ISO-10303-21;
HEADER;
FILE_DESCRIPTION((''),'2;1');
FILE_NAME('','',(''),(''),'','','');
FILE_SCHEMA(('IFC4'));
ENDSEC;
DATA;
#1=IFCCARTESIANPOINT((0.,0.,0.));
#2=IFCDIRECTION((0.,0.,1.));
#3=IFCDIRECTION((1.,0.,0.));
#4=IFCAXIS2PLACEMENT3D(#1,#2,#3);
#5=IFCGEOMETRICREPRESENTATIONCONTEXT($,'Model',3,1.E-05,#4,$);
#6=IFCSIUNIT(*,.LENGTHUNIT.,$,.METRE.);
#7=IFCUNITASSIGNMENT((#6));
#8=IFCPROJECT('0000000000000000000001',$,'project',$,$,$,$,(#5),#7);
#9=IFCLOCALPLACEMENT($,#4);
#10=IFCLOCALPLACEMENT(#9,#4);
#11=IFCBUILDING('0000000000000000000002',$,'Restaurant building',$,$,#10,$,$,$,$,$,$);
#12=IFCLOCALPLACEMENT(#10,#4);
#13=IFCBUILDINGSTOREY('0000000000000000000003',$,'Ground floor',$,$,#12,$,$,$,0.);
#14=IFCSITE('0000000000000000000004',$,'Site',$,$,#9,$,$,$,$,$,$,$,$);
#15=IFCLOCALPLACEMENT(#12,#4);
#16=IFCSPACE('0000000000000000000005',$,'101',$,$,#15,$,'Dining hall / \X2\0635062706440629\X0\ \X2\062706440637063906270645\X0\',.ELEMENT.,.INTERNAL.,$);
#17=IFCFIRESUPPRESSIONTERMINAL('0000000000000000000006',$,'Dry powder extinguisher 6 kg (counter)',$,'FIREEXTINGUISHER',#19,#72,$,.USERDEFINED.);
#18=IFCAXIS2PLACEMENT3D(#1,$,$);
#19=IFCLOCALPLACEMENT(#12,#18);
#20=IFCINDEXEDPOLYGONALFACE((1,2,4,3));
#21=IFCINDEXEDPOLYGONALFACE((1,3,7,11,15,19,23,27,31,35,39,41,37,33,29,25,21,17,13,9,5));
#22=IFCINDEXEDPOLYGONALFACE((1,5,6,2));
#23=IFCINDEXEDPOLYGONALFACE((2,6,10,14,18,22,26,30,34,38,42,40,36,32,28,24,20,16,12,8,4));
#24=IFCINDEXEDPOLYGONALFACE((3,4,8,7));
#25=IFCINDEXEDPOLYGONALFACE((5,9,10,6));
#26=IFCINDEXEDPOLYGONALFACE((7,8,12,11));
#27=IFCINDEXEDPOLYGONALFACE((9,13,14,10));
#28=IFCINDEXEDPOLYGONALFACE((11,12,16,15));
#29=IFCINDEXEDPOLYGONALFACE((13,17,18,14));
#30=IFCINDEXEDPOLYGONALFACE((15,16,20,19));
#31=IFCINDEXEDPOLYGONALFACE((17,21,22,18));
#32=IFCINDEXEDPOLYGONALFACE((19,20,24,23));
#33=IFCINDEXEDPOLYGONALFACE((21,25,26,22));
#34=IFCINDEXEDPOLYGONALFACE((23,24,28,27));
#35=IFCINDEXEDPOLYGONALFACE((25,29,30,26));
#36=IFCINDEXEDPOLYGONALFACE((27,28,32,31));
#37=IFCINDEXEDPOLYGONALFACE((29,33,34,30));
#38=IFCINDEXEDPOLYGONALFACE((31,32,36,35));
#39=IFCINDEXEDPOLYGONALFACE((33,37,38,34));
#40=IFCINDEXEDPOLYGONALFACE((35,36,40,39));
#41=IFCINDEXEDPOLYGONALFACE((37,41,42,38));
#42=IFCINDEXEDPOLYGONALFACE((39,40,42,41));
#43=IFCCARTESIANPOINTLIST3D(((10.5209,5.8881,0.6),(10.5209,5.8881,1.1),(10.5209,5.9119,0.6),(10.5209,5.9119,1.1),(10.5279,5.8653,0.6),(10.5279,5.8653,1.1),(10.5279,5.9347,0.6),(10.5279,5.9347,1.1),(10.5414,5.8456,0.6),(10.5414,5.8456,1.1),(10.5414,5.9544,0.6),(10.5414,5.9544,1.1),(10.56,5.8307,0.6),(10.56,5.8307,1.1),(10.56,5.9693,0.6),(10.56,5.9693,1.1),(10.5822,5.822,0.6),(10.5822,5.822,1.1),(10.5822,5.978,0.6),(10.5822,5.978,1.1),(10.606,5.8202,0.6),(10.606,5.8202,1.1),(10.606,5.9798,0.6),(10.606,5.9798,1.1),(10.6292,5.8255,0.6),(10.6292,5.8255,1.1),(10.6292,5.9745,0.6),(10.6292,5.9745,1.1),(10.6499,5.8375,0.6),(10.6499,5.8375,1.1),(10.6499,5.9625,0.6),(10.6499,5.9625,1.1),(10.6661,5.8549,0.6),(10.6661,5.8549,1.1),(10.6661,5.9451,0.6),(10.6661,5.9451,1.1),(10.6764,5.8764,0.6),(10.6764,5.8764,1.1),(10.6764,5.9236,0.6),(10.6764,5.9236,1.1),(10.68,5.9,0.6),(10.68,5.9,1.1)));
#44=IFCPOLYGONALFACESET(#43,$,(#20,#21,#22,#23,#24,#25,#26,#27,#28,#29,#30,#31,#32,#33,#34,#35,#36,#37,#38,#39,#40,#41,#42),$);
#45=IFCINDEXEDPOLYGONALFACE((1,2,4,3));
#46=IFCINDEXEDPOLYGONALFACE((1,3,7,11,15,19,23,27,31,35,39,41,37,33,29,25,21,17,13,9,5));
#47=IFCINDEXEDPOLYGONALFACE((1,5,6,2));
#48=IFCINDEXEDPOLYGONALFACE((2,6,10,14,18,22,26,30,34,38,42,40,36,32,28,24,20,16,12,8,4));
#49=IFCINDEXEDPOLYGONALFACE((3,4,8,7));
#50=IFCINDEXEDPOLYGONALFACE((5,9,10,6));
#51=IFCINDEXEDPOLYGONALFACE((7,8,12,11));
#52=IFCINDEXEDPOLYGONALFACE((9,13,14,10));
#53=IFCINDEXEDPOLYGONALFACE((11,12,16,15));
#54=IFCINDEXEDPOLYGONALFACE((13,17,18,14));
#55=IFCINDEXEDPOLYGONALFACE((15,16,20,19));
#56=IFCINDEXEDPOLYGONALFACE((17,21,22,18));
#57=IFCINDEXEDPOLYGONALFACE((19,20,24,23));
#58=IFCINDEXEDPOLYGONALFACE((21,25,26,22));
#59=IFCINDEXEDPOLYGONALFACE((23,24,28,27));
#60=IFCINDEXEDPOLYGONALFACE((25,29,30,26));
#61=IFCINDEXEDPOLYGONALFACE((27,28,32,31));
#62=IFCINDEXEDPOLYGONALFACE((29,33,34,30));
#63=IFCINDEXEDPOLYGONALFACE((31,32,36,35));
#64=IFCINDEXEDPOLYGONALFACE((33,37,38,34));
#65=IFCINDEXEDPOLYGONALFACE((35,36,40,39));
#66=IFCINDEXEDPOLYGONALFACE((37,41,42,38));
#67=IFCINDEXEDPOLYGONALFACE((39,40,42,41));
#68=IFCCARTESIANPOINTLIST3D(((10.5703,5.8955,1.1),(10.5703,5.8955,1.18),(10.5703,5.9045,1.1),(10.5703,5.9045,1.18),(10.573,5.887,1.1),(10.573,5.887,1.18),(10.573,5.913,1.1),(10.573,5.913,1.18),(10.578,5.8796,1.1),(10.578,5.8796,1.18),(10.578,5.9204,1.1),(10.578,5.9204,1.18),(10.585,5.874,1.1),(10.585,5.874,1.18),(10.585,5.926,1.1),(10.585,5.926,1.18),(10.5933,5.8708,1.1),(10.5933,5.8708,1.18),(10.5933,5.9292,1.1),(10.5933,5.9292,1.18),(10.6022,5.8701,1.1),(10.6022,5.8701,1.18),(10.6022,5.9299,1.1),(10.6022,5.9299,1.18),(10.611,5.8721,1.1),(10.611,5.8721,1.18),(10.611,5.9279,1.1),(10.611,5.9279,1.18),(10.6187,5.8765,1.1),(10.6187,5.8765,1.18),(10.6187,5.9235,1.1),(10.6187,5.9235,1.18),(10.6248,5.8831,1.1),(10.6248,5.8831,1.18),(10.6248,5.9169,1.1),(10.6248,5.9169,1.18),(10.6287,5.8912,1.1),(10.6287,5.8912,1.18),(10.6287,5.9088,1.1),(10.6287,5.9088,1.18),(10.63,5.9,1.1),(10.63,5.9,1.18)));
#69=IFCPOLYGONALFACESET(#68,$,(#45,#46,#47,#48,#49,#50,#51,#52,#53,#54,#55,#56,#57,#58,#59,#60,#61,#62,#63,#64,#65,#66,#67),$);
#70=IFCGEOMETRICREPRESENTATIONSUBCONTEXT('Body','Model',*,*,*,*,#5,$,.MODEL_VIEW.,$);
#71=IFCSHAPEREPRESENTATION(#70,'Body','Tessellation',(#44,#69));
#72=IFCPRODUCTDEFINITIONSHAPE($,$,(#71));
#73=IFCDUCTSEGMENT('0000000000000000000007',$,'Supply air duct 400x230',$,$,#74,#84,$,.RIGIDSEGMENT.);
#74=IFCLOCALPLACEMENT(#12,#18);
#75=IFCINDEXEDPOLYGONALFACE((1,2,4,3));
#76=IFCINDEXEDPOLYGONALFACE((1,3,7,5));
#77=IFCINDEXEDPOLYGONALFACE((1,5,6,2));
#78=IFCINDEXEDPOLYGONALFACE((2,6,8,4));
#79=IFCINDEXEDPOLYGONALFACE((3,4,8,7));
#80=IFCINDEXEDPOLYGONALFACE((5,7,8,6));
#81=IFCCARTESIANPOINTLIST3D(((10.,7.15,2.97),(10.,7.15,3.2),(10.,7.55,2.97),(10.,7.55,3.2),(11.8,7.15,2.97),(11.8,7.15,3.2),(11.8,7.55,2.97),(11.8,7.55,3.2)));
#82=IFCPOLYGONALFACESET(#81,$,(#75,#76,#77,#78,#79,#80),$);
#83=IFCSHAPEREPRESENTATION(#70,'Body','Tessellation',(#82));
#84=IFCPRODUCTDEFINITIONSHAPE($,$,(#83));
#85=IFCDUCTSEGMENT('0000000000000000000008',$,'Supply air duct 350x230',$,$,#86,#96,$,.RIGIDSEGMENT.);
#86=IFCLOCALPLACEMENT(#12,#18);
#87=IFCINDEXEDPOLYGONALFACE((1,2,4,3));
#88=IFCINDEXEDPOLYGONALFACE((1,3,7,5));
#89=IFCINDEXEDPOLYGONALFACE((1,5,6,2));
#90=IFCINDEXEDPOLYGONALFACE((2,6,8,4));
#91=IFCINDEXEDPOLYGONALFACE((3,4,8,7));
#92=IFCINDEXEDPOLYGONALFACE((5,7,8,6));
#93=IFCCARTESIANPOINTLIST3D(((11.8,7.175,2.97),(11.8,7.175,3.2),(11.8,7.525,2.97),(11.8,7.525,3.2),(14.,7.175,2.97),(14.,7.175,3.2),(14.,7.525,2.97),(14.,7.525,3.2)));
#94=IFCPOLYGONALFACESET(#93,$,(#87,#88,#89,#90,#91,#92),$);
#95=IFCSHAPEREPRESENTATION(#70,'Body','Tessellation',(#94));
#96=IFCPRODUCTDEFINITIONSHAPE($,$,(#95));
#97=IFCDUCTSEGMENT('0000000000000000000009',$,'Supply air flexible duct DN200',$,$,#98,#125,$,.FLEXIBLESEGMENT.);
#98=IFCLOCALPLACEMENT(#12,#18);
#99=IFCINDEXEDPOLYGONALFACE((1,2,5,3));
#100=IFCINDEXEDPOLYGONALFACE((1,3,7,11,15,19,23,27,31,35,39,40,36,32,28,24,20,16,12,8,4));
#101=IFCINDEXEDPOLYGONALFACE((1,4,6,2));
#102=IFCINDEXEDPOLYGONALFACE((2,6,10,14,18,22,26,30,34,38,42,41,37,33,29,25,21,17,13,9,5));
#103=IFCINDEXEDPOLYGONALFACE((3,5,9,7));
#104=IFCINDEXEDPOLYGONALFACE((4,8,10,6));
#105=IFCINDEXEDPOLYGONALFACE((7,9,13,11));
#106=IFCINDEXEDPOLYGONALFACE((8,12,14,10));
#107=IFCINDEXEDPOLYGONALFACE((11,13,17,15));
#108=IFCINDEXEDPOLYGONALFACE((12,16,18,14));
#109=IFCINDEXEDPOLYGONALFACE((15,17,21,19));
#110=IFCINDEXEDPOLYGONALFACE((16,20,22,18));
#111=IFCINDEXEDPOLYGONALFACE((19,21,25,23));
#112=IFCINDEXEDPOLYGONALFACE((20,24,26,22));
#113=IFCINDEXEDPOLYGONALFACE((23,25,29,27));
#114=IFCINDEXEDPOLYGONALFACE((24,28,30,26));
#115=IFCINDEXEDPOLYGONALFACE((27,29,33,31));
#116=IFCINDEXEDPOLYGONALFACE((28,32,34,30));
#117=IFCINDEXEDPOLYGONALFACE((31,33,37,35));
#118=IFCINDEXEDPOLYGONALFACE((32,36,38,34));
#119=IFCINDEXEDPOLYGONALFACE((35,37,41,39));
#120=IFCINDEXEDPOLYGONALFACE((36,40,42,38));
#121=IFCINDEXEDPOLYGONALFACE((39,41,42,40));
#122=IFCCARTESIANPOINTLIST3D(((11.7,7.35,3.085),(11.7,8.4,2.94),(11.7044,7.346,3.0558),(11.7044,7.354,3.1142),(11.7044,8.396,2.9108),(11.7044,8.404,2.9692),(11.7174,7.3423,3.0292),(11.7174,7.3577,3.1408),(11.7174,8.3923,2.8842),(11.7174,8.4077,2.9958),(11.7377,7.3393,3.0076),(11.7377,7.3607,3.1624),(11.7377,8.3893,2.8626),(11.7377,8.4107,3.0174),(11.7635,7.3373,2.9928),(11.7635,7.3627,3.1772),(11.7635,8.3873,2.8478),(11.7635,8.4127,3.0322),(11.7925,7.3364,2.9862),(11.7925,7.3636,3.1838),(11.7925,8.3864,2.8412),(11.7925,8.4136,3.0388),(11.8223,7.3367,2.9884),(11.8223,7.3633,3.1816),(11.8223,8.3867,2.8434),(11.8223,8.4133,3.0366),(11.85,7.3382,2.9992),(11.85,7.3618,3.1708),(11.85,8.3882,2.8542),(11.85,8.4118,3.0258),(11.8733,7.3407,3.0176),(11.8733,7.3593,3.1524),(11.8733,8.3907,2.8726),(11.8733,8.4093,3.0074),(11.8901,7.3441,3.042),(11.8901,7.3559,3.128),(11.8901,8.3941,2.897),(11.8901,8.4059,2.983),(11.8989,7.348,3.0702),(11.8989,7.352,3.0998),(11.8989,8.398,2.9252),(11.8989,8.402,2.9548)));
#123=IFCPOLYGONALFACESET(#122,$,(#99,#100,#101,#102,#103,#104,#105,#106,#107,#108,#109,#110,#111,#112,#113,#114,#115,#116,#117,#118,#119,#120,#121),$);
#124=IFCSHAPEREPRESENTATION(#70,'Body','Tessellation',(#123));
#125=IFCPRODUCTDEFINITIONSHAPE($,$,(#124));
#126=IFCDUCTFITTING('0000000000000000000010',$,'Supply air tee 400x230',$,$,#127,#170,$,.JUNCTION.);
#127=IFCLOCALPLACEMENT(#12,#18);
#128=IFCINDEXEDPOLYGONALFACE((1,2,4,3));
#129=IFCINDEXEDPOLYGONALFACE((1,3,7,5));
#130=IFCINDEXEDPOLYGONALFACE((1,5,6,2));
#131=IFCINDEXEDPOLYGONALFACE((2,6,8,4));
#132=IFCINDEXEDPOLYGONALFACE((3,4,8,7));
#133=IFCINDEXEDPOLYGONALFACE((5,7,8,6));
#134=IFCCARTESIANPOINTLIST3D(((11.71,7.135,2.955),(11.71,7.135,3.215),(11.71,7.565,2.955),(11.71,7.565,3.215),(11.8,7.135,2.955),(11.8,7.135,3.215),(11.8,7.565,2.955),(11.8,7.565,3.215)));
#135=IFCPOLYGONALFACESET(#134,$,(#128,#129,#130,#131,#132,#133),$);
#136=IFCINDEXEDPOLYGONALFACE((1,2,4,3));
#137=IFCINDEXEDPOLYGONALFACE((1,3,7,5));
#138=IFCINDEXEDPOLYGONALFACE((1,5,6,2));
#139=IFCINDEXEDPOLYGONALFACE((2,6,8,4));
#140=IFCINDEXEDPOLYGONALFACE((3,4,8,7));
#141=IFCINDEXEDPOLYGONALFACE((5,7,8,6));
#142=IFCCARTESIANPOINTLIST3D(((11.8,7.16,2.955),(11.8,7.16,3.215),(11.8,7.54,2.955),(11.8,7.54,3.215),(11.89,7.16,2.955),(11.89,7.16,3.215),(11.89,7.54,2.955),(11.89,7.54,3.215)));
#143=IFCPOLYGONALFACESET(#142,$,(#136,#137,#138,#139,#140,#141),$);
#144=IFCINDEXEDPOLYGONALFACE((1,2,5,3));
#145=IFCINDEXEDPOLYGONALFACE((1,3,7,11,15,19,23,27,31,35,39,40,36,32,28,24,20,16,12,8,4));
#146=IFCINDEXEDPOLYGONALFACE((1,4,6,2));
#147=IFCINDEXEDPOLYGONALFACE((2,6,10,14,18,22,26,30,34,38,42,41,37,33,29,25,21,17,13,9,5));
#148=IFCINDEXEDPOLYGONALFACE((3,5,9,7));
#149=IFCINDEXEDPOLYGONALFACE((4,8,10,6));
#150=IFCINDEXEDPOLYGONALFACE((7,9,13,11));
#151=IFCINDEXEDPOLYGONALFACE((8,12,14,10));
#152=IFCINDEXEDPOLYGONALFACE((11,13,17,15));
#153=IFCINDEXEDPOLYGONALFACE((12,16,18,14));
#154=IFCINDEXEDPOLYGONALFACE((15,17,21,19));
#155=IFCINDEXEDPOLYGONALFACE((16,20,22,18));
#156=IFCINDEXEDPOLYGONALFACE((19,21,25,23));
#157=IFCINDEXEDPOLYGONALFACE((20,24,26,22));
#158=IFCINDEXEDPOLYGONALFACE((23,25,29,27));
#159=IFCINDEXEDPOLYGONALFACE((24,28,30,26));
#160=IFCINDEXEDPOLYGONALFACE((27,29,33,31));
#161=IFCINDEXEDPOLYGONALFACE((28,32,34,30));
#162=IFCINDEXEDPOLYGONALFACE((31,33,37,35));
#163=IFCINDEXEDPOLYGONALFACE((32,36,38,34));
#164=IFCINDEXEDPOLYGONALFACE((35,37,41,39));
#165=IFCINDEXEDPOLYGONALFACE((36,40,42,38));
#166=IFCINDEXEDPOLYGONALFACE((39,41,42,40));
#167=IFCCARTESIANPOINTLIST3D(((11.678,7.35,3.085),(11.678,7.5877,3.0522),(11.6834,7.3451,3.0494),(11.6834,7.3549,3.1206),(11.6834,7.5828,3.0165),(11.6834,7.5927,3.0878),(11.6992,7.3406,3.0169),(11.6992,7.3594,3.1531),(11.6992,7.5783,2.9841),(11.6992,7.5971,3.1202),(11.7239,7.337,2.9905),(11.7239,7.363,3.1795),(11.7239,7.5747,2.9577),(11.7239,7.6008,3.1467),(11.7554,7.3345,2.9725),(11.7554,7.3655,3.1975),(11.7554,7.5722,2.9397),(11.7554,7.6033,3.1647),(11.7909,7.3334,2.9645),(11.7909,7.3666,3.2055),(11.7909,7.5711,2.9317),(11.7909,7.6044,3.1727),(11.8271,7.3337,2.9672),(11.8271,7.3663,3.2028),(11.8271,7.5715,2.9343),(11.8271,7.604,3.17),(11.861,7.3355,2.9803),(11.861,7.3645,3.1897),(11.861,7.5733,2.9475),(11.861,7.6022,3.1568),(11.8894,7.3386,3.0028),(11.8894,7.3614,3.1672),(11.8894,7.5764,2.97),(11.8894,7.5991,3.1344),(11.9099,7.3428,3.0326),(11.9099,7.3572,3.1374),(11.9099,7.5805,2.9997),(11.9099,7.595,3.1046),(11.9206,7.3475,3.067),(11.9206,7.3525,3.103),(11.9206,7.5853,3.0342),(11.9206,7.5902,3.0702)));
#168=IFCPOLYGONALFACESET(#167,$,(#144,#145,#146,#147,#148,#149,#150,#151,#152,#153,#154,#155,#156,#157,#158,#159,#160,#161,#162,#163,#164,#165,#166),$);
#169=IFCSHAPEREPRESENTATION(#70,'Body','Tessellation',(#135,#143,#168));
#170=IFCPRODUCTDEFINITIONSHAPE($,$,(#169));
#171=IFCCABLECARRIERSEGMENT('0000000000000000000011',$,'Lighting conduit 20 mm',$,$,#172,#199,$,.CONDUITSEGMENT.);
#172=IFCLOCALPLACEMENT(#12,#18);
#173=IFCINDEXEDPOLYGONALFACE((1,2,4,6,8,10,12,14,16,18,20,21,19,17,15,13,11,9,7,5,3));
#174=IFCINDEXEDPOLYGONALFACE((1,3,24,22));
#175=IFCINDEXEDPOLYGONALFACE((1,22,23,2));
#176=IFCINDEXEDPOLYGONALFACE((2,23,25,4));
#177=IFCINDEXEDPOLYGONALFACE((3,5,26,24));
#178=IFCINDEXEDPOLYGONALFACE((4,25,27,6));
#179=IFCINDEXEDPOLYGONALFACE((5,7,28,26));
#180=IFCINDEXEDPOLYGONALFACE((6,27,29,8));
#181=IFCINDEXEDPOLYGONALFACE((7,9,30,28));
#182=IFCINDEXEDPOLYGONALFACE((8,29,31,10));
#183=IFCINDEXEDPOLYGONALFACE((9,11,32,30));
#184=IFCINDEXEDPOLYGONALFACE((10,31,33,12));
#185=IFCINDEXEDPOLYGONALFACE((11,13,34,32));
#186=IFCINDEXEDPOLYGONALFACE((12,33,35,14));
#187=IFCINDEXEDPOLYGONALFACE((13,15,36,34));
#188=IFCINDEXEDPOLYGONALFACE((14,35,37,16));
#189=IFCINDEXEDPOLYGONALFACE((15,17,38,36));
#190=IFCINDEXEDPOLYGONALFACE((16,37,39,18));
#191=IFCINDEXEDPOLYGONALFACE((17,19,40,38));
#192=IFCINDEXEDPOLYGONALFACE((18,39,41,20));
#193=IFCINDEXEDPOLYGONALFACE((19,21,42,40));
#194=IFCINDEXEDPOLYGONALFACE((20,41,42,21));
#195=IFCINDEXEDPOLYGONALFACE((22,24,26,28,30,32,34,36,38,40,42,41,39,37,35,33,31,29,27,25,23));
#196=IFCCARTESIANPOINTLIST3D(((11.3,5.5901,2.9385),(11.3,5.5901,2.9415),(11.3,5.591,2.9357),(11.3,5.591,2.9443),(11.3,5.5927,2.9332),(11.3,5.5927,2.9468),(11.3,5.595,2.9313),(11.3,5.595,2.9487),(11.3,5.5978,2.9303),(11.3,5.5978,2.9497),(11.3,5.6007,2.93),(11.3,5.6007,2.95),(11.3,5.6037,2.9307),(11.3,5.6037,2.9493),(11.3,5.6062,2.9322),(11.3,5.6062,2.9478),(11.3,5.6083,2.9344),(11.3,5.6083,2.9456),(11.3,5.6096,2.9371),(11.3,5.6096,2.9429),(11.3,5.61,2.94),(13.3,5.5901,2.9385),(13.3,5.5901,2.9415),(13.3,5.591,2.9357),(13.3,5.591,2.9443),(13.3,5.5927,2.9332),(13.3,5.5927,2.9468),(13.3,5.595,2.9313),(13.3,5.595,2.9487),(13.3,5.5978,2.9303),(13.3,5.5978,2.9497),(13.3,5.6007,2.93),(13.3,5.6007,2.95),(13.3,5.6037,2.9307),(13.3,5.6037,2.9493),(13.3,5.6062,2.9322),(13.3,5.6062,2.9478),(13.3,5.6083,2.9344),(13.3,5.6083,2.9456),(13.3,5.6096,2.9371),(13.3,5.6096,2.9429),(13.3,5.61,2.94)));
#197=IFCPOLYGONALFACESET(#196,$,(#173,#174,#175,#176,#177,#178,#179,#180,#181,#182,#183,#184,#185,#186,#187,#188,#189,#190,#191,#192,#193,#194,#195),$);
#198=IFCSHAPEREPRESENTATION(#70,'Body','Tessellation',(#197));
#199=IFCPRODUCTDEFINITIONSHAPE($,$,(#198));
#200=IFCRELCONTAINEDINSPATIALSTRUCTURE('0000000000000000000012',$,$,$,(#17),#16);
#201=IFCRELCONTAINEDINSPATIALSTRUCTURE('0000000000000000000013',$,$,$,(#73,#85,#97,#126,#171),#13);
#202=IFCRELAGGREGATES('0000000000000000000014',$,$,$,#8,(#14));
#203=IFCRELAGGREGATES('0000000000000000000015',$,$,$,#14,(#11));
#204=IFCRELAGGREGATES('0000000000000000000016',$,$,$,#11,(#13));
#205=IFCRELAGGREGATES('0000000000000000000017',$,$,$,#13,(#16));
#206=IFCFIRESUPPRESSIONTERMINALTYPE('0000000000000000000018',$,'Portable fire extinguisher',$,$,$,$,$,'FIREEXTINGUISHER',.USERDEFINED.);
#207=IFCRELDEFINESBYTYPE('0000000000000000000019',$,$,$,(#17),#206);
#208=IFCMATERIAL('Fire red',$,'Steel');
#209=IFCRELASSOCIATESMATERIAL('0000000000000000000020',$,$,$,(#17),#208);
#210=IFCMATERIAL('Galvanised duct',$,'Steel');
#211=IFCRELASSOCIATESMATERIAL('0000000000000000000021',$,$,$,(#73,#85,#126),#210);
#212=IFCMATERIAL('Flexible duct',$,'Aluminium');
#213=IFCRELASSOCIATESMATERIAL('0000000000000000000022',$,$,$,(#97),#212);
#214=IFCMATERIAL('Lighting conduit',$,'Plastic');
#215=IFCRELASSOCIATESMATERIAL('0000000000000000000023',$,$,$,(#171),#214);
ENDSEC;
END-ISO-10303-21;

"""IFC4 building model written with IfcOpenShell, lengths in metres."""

from ifc_helpers import new_model, si_unit, frame, origin, origin_with_axes, origin_2d, place, context, subcontext, project, spatial, rectangle, circle, extrude, source, transform, mapped, material, type_object, type_shapes, element, save


model = new_model("IFC4")

# Units and contexts
model_context = context("Model", 3, precision=1e-05, world=origin_with_axes())
body_context = subcontext(model_context, "Body", "Model", "MODEL_VIEW")
ifc_project = project(units=[si_unit("LENGTHUNIT", "METRE")], contexts=[model_context])

# Site, building, storey
site_placement = place(None, origin_with_axes())
site = spatial("IfcSite", under=ifc_project, at=site_placement, Name="Site")
building_placement = place(site_placement, origin_with_axes())
building = spatial("IfcBuilding", under=site, at=building_placement, Name="Restaurant building")
storey_placement = place(building_placement, origin_with_axes())
storey = spatial("IfcBuildingStorey", under=building, at=storey_placement, Name="Ground floor", Elevation=0.0)

# Shared definitions
space_1_placement = place(storey_placement, origin_with_axes())
space_1 = spatial("IfcSpace", under=storey, at=space_1_placement, Name="101", LongName="Dining hall / صالة الطعام", CompositionType="ELEMENT", PredefinedType="INTERNAL")

# Fire suppression terminal
ifc_material_1 = material(Name="Fire red", Category="Steel")
fire_suppression_terminal_type_1 = type_object("IfcFireSuppressionTerminalType", Name="Portable fire extinguisher", ElementType="FIREEXTINGUISHER", PredefinedType="USERDEFINED")
shared_shape_1 = source(origin(), body_context, "Body", "SweptSolid", [
    extrude(circle(Radius=0.08, at=origin_2d()), origin(), (0.0, 0.0, 1.0), 0.5),
    extrude(circle(Radius=0.03, at=origin_2d()), frame((0.0, 0.0, 0.5)), (0.0, 0.0, 1.0), 0.08),
])
type_shapes(fire_suppression_terminal_type_1, [shared_shape_1])
fire_suppression_terminal_1_placement = place(storey_placement, frame((10.6, 5.9, 0.6)))
element("IfcFireSuppressionTerminal", 1, at=fire_suppression_terminal_1_placement, inside=space_1, type_object=fire_suppression_terminal_type_1, material=ifc_material_1, Name="Dry powder extinguisher 6 kg (counter)", ObjectType="FIREEXTINGUISHER", PredefinedType="USERDEFINED", context=body_context, shape_type="MappedRepresentation", body=[
    mapped(shared_shape_1, transform((0.0, 0.0, 0.0))),
])

# Duct segments
ifc_material_2 = material(Name="Galvanised duct", Category="Steel")
duct_segment_1_placement = place(storey_placement, frame((10.0, 7.35, 3.085)))
element("IfcDuctSegment", 2, at=duct_segment_1_placement, inside=storey, material=ifc_material_2, Name="Supply air duct 400x230", PredefinedType="RIGIDSEGMENT", context=body_context, shape_type="SweptSolid", body=[
    extrude(rectangle(XDim=0.4, YDim=0.23, at=origin_2d()), frame((0.0, 0.0, 0.0), z_axis=(1.0, 0.0, 0.0), x_axis=(0.0, 1.0, 0.0)), (0.0, 0.0, 1.0), 1.8),
])
duct_segment_2_placement = place(storey_placement, frame((11.8, 7.35, 3.085)))
element("IfcDuctSegment", 3, at=duct_segment_2_placement, inside=storey, material=ifc_material_2, Name="Supply air duct 350x230", PredefinedType="RIGIDSEGMENT", context=body_context, shape_type="SweptSolid", body=[
    extrude(rectangle(XDim=0.35, YDim=0.23, at=origin_2d()), frame((0.0, 0.0, 0.0), z_axis=(1.0, 0.0, 0.0), x_axis=(0.0, 1.0, 0.0)), (0.0, 0.0, 1.0), 2.2),
])
ifc_material_3 = material(Name="Flexible duct", Category="Aluminium")
duct_segment_3_placement = place(storey_placement, frame((11.8, 7.35, 3.085)))
element("IfcDuctSegment", 4, at=duct_segment_3_placement, inside=storey, material=ifc_material_3, Name="Supply air flexible duct DN200", PredefinedType="FLEXIBLESEGMENT", context=body_context, shape_type="SweptSolid", body=[
    extrude(circle(Radius=0.1, at=origin_2d()), frame((0.0, 0.0, 0.0), z_axis=(0.0, 0.990599, -0.136797), x_axis=(-1.0, 0.0, 0.0)), (0.0, 0.0, 1.0), 1.06),
])

# Duct fitting
duct_fitting_placement = place(storey_placement, frame((11.8, 7.35, 3.085)))
element("IfcDuctFitting", 5, at=duct_fitting_placement, inside=storey, material=ifc_material_2, Name="Supply air tee 400x230", PredefinedType="JUNCTION", context=body_context, shape_type="SweptSolid", body=[
    extrude(rectangle(XDim=0.43, YDim=0.26, at=origin_2d()), frame((0.0, 0.0, 0.0), z_axis=(-1.0, 0.0, 0.0), x_axis=(0.0, -1.0, 0.0)), (0.0, 0.0, 1.0), 0.09),
    extrude(rectangle(XDim=0.38, YDim=0.26, at=origin_2d()), frame((0.0, 0.0, 0.0), z_axis=(1.0, 0.0, 0.0), x_axis=(0.0, 1.0, 0.0)), (0.0, 0.0, 1.0), 0.09),
    extrude(circle(Radius=0.122, at=origin_2d()), frame((0.0, 0.0, 0.0), z_axis=(0.0, 0.990599, -0.136797), x_axis=(-1.0, 0.0, 0.0)), (0.0, 0.0, 1.0), 0.24),
])

# Cable carrier segment
ifc_material_4 = material(Name="Lighting conduit", Category="Plastic")
cable_carrier_segment_1_placement = place(storey_placement, frame((11.3, 5.6, 2.94)))
element("IfcCableCarrierSegment", 6, at=cable_carrier_segment_1_placement, inside=storey, material=ifc_material_4, Name="Lighting conduit 20 mm", PredefinedType="CONDUITSEGMENT", context=body_context, shape_type="SweptSolid", body=[
    extrude(circle(Radius=0.01, at=origin_2d()), frame((0.0, 0.0, 0.0), z_axis=(1.0, 0.0, 0.0), x_axis=(0.0, 1.0, 0.0)), (0.0, 0.0, 1.0), 2.0),
])

save(model, "model.ifc")
